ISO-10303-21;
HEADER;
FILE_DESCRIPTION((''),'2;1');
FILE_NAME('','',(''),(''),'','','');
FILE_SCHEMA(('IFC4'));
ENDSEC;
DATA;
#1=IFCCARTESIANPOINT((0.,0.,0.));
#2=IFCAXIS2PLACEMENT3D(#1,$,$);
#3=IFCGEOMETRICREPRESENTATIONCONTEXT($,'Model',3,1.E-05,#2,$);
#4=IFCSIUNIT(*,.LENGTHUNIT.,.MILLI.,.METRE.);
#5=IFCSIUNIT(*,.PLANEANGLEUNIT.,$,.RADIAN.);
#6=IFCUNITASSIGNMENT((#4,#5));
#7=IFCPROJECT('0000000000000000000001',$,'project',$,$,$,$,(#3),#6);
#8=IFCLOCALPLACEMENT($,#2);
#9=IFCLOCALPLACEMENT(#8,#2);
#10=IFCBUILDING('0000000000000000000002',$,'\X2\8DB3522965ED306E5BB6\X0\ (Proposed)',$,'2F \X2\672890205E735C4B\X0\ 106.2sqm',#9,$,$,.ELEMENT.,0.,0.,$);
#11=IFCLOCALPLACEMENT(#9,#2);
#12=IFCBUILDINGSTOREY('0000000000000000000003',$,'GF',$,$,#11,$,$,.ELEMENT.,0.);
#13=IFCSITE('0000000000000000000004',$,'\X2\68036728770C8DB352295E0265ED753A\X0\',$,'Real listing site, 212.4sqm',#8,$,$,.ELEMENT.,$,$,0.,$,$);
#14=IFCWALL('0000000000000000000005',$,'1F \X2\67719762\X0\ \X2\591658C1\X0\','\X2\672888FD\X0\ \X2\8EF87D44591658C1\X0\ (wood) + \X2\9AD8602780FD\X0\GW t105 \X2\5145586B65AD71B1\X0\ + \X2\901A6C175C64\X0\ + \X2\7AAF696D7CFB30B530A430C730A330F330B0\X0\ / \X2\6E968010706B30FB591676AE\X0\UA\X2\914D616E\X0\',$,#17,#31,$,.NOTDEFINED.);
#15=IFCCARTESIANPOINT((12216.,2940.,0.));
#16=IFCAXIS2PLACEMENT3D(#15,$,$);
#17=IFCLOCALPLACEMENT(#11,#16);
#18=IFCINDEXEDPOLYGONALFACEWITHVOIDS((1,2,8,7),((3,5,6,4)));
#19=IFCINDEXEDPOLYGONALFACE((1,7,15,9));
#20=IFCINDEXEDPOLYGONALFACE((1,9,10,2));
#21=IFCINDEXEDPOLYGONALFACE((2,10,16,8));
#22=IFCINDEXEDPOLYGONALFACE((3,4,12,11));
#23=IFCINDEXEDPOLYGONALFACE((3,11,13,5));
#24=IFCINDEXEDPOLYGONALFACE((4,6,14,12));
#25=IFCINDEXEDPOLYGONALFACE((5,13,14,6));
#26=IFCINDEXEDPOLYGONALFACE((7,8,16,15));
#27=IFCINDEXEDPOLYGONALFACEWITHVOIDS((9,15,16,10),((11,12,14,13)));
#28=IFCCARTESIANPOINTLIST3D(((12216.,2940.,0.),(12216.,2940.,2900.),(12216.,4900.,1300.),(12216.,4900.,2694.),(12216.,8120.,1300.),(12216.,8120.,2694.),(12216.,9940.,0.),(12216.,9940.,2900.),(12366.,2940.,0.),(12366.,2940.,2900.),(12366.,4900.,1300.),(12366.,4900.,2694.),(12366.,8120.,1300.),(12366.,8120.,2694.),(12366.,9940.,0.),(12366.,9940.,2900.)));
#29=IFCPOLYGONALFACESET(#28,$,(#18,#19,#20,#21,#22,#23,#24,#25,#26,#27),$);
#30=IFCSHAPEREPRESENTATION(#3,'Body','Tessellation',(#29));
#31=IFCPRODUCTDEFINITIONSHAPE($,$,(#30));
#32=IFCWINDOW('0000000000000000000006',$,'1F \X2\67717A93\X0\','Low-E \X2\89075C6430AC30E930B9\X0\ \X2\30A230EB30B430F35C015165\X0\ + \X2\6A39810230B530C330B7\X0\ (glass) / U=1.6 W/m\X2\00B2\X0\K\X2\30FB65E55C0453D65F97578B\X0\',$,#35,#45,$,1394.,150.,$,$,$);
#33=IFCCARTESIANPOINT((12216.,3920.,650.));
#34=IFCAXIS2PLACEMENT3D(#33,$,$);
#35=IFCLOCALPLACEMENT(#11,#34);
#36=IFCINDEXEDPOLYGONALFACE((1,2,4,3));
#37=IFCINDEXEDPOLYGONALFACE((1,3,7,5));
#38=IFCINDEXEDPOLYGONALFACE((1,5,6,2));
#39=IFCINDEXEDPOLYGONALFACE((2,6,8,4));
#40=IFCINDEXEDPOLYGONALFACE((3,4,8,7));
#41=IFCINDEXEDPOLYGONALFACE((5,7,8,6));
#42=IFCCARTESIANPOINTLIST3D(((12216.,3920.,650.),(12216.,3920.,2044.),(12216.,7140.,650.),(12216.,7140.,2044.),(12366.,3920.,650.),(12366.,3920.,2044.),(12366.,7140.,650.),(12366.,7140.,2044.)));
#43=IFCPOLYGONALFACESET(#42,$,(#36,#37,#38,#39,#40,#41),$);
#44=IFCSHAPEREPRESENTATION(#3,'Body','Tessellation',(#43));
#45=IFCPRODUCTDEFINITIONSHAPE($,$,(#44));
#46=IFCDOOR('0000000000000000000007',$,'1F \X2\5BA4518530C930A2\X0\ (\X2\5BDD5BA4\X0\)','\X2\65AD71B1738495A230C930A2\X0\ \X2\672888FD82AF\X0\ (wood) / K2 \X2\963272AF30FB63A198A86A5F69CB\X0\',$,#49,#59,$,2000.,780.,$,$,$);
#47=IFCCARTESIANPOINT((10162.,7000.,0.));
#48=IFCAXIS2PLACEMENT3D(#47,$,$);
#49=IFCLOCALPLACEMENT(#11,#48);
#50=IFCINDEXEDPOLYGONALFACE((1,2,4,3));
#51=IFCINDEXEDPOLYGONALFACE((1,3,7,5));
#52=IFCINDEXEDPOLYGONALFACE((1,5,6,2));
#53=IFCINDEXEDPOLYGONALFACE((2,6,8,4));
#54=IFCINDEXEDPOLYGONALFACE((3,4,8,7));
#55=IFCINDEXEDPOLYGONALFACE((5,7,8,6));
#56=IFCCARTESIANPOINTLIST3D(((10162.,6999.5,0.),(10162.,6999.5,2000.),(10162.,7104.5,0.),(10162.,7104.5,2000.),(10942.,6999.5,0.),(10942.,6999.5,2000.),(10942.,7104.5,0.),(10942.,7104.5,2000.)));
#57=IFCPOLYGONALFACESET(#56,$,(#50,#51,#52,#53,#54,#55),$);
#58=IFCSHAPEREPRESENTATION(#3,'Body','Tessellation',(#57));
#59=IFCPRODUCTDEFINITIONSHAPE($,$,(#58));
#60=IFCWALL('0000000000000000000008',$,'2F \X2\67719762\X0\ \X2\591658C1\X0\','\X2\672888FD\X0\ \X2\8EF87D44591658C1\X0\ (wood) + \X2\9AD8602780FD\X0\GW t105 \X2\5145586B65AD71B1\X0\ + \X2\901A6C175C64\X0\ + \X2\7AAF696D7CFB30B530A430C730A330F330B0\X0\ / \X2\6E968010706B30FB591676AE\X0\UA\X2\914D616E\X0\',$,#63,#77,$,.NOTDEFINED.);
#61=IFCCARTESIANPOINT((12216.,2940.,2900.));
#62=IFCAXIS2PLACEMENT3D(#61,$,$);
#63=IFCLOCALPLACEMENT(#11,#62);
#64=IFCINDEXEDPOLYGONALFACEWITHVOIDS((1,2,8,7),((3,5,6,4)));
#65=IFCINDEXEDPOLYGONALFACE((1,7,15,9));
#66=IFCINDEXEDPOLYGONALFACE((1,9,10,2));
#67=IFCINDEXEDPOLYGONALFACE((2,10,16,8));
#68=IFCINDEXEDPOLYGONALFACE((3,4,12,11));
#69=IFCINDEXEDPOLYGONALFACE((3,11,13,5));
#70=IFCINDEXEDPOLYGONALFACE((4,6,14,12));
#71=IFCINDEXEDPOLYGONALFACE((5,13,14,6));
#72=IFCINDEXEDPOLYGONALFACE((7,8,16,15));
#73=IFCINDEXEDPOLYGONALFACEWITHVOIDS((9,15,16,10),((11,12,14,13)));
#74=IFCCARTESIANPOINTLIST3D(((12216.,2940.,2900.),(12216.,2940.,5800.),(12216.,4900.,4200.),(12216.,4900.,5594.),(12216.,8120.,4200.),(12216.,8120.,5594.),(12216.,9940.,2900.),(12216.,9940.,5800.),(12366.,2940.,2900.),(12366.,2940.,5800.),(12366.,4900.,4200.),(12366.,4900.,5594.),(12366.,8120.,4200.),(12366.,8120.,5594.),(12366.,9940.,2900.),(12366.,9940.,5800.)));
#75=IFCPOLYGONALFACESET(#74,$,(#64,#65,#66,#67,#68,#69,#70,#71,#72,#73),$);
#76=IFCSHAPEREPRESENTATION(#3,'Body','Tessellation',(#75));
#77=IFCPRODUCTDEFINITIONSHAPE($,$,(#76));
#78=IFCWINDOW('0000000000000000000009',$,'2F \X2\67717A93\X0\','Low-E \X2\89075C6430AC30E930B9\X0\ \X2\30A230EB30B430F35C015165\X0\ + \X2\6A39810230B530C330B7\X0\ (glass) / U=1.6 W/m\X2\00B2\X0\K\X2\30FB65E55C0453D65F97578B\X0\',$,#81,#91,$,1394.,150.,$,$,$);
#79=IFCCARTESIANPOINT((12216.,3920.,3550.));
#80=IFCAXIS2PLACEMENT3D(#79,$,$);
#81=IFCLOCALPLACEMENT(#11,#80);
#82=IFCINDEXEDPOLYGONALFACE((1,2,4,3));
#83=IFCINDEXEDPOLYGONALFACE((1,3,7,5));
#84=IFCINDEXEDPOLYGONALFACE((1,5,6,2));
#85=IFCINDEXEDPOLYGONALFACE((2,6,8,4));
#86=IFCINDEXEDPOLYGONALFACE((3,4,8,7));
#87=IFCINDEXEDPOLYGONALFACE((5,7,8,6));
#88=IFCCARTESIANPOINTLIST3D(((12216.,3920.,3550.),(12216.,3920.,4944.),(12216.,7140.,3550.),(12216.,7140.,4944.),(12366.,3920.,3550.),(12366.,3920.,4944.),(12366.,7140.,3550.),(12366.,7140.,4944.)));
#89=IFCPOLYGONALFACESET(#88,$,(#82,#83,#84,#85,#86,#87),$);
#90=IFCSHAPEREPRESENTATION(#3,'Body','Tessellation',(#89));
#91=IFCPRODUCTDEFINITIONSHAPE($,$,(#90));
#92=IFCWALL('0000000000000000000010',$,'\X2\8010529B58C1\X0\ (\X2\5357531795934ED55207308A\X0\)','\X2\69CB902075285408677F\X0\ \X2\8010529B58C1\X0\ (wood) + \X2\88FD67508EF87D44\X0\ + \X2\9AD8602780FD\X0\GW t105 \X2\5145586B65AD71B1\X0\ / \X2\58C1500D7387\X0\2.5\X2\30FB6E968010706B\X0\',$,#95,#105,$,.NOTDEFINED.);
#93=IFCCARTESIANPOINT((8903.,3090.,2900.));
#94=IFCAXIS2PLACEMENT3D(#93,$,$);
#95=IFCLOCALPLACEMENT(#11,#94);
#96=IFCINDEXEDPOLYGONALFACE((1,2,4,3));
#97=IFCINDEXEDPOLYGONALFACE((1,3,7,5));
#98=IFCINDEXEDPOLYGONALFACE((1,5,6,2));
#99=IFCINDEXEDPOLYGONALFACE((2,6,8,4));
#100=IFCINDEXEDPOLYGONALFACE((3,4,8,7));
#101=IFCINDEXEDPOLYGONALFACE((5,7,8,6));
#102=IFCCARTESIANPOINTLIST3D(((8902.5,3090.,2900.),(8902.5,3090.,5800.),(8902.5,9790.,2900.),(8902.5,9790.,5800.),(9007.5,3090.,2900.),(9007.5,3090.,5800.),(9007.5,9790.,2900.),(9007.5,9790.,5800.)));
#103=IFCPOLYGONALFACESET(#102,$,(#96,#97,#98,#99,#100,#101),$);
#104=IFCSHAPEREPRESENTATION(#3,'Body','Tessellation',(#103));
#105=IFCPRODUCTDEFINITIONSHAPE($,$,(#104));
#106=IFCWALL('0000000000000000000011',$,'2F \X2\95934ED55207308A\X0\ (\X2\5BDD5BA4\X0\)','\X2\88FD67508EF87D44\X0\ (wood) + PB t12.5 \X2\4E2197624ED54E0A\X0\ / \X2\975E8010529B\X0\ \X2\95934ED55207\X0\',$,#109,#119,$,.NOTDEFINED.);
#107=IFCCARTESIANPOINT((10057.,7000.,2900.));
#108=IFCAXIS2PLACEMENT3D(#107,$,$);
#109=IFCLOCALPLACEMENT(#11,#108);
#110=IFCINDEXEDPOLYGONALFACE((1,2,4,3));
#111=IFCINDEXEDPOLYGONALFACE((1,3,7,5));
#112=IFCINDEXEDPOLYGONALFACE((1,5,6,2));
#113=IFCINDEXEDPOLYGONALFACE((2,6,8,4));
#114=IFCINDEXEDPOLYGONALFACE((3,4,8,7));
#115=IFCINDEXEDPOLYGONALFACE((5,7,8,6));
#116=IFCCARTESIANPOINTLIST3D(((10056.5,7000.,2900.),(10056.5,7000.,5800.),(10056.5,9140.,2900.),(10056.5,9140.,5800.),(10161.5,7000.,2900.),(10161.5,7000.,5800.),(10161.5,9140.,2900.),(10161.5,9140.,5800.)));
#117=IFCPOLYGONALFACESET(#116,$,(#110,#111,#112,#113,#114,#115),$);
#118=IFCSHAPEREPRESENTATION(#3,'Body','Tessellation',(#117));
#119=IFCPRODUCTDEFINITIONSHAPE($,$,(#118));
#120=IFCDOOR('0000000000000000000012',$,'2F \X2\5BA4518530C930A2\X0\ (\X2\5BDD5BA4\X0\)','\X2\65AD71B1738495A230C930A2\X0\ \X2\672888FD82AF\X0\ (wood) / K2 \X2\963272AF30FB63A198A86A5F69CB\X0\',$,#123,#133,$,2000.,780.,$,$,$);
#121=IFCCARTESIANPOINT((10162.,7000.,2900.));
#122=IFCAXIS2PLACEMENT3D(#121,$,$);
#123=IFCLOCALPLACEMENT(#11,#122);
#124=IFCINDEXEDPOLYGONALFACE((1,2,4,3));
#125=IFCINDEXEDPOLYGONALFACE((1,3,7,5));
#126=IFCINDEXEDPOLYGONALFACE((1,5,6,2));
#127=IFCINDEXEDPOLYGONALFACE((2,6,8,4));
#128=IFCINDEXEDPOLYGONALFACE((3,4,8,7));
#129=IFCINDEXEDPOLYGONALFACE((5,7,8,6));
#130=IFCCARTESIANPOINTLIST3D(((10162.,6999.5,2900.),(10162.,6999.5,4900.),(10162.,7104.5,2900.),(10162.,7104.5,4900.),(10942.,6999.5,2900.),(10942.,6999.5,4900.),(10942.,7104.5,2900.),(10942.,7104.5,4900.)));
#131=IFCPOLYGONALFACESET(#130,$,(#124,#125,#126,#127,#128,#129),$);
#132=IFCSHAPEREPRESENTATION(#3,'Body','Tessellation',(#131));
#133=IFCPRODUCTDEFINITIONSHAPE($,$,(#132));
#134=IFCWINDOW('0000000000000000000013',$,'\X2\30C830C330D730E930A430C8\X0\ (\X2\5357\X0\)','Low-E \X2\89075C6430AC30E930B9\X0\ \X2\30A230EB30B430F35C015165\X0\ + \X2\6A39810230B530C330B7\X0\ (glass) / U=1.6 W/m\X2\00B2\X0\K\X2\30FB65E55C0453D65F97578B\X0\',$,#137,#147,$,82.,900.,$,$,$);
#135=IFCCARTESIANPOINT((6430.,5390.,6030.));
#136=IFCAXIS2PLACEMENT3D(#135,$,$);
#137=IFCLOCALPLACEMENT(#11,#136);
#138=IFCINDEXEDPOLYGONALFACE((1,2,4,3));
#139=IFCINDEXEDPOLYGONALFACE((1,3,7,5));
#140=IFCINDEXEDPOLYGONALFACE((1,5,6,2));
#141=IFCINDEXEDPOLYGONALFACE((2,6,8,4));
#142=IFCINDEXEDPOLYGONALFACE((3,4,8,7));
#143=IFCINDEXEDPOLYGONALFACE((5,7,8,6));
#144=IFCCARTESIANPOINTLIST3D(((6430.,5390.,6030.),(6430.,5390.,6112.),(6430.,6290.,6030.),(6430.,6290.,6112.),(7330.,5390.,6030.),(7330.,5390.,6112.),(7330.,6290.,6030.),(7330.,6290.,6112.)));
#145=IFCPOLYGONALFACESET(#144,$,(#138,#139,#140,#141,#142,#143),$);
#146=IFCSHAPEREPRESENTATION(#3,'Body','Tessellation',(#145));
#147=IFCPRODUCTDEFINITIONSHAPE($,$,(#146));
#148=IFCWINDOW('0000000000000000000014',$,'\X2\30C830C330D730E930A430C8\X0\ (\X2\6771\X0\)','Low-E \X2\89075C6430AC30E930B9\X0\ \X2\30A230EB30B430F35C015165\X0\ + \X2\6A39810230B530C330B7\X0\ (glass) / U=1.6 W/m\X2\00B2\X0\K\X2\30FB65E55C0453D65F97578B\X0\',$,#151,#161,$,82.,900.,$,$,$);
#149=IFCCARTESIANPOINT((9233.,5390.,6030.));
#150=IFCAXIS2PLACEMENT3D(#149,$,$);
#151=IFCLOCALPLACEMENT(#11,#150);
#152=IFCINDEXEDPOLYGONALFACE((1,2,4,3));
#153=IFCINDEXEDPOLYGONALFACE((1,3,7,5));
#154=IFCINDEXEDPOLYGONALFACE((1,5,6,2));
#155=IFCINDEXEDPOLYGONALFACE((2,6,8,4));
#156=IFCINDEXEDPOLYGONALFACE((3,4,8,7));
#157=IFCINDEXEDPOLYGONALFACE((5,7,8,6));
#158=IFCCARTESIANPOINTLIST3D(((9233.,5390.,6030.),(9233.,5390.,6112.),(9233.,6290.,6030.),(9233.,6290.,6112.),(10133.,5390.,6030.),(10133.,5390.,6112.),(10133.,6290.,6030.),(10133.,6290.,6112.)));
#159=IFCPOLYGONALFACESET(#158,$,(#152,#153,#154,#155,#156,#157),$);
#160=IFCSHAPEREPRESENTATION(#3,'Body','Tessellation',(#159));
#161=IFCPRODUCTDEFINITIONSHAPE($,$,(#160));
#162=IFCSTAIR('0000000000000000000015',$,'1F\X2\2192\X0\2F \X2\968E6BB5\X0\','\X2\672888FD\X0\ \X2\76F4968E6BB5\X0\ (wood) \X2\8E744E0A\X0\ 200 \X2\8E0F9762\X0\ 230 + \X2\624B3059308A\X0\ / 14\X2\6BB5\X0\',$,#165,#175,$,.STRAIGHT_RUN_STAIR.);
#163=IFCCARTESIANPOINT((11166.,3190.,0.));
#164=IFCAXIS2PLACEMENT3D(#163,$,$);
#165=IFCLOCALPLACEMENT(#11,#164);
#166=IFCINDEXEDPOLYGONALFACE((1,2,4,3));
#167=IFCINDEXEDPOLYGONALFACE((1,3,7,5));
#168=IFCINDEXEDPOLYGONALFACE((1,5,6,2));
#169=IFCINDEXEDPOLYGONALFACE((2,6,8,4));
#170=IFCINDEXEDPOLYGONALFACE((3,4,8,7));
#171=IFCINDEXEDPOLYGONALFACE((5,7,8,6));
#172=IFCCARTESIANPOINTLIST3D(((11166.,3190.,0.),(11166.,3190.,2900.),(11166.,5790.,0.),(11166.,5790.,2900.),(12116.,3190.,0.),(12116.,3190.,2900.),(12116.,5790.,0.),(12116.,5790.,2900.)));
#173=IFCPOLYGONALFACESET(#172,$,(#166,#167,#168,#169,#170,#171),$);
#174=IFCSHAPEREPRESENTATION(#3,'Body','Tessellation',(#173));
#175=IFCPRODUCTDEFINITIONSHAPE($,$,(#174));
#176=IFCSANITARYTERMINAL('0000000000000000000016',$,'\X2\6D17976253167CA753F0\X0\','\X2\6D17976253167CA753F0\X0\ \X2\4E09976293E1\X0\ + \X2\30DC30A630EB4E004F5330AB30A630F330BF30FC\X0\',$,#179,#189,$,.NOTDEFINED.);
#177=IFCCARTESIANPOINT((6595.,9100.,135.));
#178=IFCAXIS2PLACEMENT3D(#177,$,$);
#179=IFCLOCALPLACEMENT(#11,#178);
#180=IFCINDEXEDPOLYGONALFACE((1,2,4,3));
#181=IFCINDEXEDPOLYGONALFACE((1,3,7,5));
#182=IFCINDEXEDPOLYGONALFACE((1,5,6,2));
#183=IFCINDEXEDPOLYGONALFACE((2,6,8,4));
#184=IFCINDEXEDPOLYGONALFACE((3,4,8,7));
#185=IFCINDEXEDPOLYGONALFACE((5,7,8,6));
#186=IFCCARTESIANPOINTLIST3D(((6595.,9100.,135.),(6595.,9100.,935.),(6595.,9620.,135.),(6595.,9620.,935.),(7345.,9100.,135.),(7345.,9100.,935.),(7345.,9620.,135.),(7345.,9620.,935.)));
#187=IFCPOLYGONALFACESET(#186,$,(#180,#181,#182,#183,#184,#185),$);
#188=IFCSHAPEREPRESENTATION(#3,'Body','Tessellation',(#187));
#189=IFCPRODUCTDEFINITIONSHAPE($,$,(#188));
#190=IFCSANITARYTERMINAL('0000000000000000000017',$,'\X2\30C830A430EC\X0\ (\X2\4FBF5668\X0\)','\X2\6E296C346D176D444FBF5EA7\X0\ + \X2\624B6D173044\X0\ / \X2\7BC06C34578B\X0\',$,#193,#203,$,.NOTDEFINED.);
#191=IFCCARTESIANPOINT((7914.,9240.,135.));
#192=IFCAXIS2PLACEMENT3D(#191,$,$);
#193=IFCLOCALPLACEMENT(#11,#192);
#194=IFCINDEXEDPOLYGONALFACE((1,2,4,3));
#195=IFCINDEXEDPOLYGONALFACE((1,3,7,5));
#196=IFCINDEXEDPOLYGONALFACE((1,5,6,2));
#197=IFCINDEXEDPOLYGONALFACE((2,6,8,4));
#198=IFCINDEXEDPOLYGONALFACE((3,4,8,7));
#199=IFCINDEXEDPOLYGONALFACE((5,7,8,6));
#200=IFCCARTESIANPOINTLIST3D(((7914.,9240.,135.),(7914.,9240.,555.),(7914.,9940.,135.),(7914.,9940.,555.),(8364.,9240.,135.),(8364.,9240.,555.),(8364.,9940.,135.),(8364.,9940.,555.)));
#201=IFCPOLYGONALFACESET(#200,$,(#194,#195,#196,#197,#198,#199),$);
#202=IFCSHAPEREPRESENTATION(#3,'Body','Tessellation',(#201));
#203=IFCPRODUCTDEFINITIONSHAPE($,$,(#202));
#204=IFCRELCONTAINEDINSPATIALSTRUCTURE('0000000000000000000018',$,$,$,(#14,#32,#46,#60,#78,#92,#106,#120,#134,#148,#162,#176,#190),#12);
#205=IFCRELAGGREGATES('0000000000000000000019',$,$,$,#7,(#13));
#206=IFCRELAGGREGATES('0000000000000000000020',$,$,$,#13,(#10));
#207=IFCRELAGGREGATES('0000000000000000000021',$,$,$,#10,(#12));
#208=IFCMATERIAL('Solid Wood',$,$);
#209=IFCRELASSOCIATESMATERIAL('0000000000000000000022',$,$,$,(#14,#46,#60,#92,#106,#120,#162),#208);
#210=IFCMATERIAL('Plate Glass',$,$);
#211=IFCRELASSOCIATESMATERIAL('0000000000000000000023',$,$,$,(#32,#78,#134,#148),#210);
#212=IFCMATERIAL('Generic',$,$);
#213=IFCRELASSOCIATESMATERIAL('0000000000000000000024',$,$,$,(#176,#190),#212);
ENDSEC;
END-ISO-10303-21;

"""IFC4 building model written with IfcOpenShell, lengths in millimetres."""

from ifc_helpers import new_model, si_unit, frame, frame_2d, origin, place, context, project, spatial, rectangle, extrude, material, element, fill, save


model = new_model("IFC4")

# Units and contexts
model_context = context("Model", 3, precision=1e-05, world=origin())
ifc_project = project(units=[si_unit("LENGTHUNIT", "METRE", prefix="MILLI"), si_unit("PLANEANGLEUNIT", "RADIAN")], contexts=[model_context])

# Site, building, storey
site_placement = place(None, origin())
site = spatial("IfcSite", under=ifc_project, at=site_placement, Name="栃木県足利市旭町", ObjectType="Real listing site, 212.4sqm", CompositionType="ELEMENT", RefElevation=0.0)
building_placement = place(site_placement, origin())
building = spatial("IfcBuilding", under=site, at=building_placement, Name="足利旭の家 (Proposed)", ObjectType="2F 木造平屋 106.2sqm", CompositionType="ELEMENT", ElevationOfRefHeight=0.0, ElevationOfTerrain=0.0)
storey_placement = place(building_placement, origin())
storey = spatial("IfcBuildingStorey", under=building, at=storey_placement, Name="GF", CompositionType="ELEMENT", Elevation=0.0)

# Wall, opening, window
ifc_material_1 = material(Name="Solid Wood")
wall_1_placement = place(storey_placement, frame((12216.0, 2940.0, 0.0)))
wall_1 = element("IfcWall", 1, at=wall_1_placement, inside=storey, material=ifc_material_1, Name="1F 東面 外壁", Description="木製 軸組外壁 (wood) + 高性能GW t105 充填断熱 + 通気層 + 窯業系サイディング / 準耐火・外皮UA配慮", PredefinedType="NOTDEFINED", context=model_context, shape_type="SweptSolid", body=[
    extrude(rectangle(XDim=150.0, YDim=7000.0, at=frame_2d((75.0, 3500.0))), frame((12216.0, 2940.0, 0.0)), (0.0, 0.0, 1.0), 2900.0),
])
opening_1_placement = place(storey_placement, frame((12216.0, 3920.0, 650.0)))
opening_1 = element("IfcOpeningElement", 2, at=opening_1_placement, cuts=wall_1, PredefinedType="NOTDEFINED", context=model_context, shape_type="SweptSolid", body=[
    extrude(rectangle(XDim=150.0, YDim=3220.0, at=frame_2d((75.0, 1610.0))), frame((12216.0, 3920.0, 650.0)), (0.0, 0.0, 1.0), 1394.0),
])
ifc_material_2 = material(Name="Plate Glass")
window_1_placement = place(storey_placement, frame((12216.0, 3920.0, 650.0)))
window_1 = element("IfcWindow", 3, at=window_1_placement, inside=storey, material=ifc_material_2, Name="1F 東窓", Description="Low-E 複層ガラス アルゴン封入 + 樹脂サッシ (glass) / U=1.6 W/m²K・日射取得型", OverallHeight=1394.0, OverallWidth=150.0, context=model_context, shape_type="SweptSolid", body=[
    extrude(rectangle(XDim=150.0, YDim=3220.0, at=frame_2d((75.0, 1610.0))), frame((12216.0, 3920.0, 650.0)), (0.0, 0.0, 1.0), 1394.0),
])
fill(opening_1, window_1)

# Door
door_1_placement = place(storey_placement, frame((10162.0, 7000.0, 0.0)))
element("IfcDoor", 4, at=door_1_placement, inside=storey, material=ifc_material_1, Name="1F 室内ドア (寝室)", Description="断熱玄関ドア 木製芯 (wood) / K2 防犯・採風機構", OverallHeight=2000.0, OverallWidth=780.0, context=model_context, shape_type="SweptSolid", body=[
    extrude(rectangle(XDim=780.0, YDim=105.0, at=frame_2d((390.0, 52.0))), frame((10162.0, 7000.0, 0.0)), (0.0, 0.0, 1.0), 2000.0),
])

# Wall, opening, window
wall_2_placement = place(storey_placement, frame((12216.0, 2940.0, 2900.0)))
wall_2 = element("IfcWall", 5, at=wall_2_placement, inside=storey, material=ifc_material_1, Name="2F 東面 外壁", Description="木製 軸組外壁 (wood) + 高性能GW t105 充填断熱 + 通気層 + 窯業系サイディング / 準耐火・外皮UA配慮", PredefinedType="NOTDEFINED", context=model_context, shape_type="SweptSolid", body=[
    extrude(rectangle(XDim=150.0, YDim=7000.0, at=frame_2d((75.0, 3500.0))), frame((12216.0, 2940.0, 2900.0)), (0.0, 0.0, 1.0), 2900.0),
])
opening_2_placement = place(storey_placement, frame((12216.0, 3920.0, 3550.0)))
opening_2 = element("IfcOpeningElement", 6, at=opening_2_placement, cuts=wall_2, PredefinedType="NOTDEFINED", context=model_context, shape_type="SweptSolid", body=[
    extrude(rectangle(XDim=150.0, YDim=3220.0, at=frame_2d((75.0, 1610.0))), frame((12216.0, 3920.0, 3550.0)), (0.0, 0.0, 1.0), 1394.0),
])
window_2_placement = place(storey_placement, frame((12216.0, 3920.0, 3550.0)))
window_2 = element("IfcWindow", 7, at=window_2_placement, inside=storey, material=ifc_material_2, Name="2F 東窓", Description="Low-E 複層ガラス アルゴン封入 + 樹脂サッシ (glass) / U=1.6 W/m²K・日射取得型", OverallHeight=1394.0, OverallWidth=150.0, context=model_context, shape_type="SweptSolid", body=[
    extrude(rectangle(XDim=150.0, YDim=3220.0, at=frame_2d((75.0, 1610.0))), frame((12216.0, 3920.0, 3550.0)), (0.0, 0.0, 1.0), 1394.0),
])
fill(opening_2, window_2)

# Walls
wall_3_placement = place(storey_placement, frame((8903.0, 3090.0, 2900.0)))
element("IfcWall", 8, at=wall_3_placement, inside=storey, material=ifc_material_1, Name="耐力壁 (南北間仕切り)", Description="構造用合板 耐力壁 (wood) + 製材軸組 + 高性能GW t105 充填断熱 / 壁倍率2.5・準耐火", PredefinedType="NOTDEFINED", context=model_context, shape_type="SweptSolid", body=[
    extrude(rectangle(XDim=105.0, YDim=6700.0, at=frame_2d((52.0, 3350.0))), frame((8903.0, 3090.0, 2900.0)), (0.0, 0.0, 1.0), 2900.0),
])
wall_4_placement = place(storey_placement, frame((10057.0, 7000.0, 2900.0)))
element("IfcWall", 9, at=wall_4_placement, inside=storey, material=ifc_material_1, Name="2F 間仕切り (寝室)", Description="製材軸組 (wood) + PB t12.5 両面仕上 / 非耐力 間仕切", PredefinedType="NOTDEFINED", context=model_context, shape_type="SweptSolid", body=[
    extrude(rectangle(XDim=105.0, YDim=2140.0, at=frame_2d((52.0, 1070.0))), frame((10057.0, 7000.0, 2900.0)), (0.0, 0.0, 1.0), 2900.0),
])

# Door
door_2_placement = place(storey_placement, frame((10162.0, 7000.0, 2900.0)))
element("IfcDoor", 10, at=door_2_placement, inside=storey, material=ifc_material_1, Name="2F 室内ドア (寝室)", Description="断熱玄関ドア 木製芯 (wood) / K2 防犯・採風機構", OverallHeight=2000.0, OverallWidth=780.0, context=model_context, shape_type="SweptSolid", body=[
    extrude(rectangle(XDim=780.0, YDim=105.0, at=frame_2d((390.0, 52.0))), frame((10162.0, 7000.0, 2900.0)), (0.0, 0.0, 1.0), 2000.0),
])

# Windows
window_3_placement = place(storey_placement, frame((6430.0, 5390.0, 6030.0)))
element("IfcWindow", 11, at=window_3_placement, inside=storey, material=ifc_material_2, Name="トップライト (南)", Description="Low-E 複層ガラス アルゴン封入 + 樹脂サッシ (glass) / U=1.6 W/m²K・日射取得型", OverallHeight=82.0, OverallWidth=900.0, context=model_context, shape_type="SweptSolid", body=[
    extrude(rectangle(XDim=900.0, YDim=900.0, at=frame_2d((450.0, 450.0))), frame((6430.0, 5390.0, 6030.0)), (0.0, 0.0, 1.0), 82.0),
])
window_4_placement = place(storey_placement, frame((9233.0, 5390.0, 6030.0)))
element("IfcWindow", 12, at=window_4_placement, inside=storey, material=ifc_material_2, Name="トップライト (東)", Description="Low-E 複層ガラス アルゴン封入 + 樹脂サッシ (glass) / U=1.6 W/m²K・日射取得型", OverallHeight=82.0, OverallWidth=900.0, context=model_context, shape_type="SweptSolid", body=[
    extrude(rectangle(XDim=900.0, YDim=900.0, at=frame_2d((450.0, 450.0))), frame((9233.0, 5390.0, 6030.0)), (0.0, 0.0, 1.0), 82.0),
])

# Stair
stair_placement = place(storey_placement, frame((11166.0, 3190.0, 0.0)))
element("IfcStair", 13, at=stair_placement, inside=storey, material=ifc_material_1, Name="1F→2F 階段", Description="木製 直階段 (wood) 蹴上 200 踏面 230 + 手すり / 14段", PredefinedType="STRAIGHT_RUN_STAIR", context=model_context, shape_type="SweptSolid", body=[
    extrude(rectangle(XDim=950.0, YDim=2600.0, at=frame_2d((475.0, 1300.0))), frame((11166.0, 3190.0, 0.0)), (0.0, 0.0, 1.0), 2900.0),
])

# Sanitary terminals
ifc_material_3 = material(Name="Generic")
sanitary_terminal_1_placement = place(storey_placement, frame((6595.0, 9100.0, 135.0)))
element("IfcSanitaryTerminal", 14, at=sanitary_terminal_1_placement, inside=storey, material=ifc_material_3, Name="洗面化粧台", Description="洗面化粧台 三面鏡 + ボウル一体カウンター", PredefinedType="NOTDEFINED", context=model_context, shape_type="SweptSolid", body=[
    extrude(rectangle(XDim=750.0, YDim=520.0, at=frame_2d((375.0, 260.0))), frame((6595.0, 9100.0, 135.0)), (0.0, 0.0, 1.0), 800.0),
])
sanitary_terminal_2_placement = place(storey_placement, frame((7914.0, 9240.0, 135.0)))
element("IfcSanitaryTerminal", 15, at=sanitary_terminal_2_placement, inside=storey, material=ifc_material_3, Name="トイレ (便器)", Description="温水洗浄便座 + 手洗い / 節水型", PredefinedType="NOTDEFINED", context=model_context, shape_type="SweptSolid", body=[
    extrude(rectangle(XDim=450.0, YDim=700.0, at=frame_2d((225.0, 350.0))), frame((7914.0, 9240.0, 135.0)), (0.0, 0.0, 1.0), 420.0),
])

save(model, "model.ifc")
